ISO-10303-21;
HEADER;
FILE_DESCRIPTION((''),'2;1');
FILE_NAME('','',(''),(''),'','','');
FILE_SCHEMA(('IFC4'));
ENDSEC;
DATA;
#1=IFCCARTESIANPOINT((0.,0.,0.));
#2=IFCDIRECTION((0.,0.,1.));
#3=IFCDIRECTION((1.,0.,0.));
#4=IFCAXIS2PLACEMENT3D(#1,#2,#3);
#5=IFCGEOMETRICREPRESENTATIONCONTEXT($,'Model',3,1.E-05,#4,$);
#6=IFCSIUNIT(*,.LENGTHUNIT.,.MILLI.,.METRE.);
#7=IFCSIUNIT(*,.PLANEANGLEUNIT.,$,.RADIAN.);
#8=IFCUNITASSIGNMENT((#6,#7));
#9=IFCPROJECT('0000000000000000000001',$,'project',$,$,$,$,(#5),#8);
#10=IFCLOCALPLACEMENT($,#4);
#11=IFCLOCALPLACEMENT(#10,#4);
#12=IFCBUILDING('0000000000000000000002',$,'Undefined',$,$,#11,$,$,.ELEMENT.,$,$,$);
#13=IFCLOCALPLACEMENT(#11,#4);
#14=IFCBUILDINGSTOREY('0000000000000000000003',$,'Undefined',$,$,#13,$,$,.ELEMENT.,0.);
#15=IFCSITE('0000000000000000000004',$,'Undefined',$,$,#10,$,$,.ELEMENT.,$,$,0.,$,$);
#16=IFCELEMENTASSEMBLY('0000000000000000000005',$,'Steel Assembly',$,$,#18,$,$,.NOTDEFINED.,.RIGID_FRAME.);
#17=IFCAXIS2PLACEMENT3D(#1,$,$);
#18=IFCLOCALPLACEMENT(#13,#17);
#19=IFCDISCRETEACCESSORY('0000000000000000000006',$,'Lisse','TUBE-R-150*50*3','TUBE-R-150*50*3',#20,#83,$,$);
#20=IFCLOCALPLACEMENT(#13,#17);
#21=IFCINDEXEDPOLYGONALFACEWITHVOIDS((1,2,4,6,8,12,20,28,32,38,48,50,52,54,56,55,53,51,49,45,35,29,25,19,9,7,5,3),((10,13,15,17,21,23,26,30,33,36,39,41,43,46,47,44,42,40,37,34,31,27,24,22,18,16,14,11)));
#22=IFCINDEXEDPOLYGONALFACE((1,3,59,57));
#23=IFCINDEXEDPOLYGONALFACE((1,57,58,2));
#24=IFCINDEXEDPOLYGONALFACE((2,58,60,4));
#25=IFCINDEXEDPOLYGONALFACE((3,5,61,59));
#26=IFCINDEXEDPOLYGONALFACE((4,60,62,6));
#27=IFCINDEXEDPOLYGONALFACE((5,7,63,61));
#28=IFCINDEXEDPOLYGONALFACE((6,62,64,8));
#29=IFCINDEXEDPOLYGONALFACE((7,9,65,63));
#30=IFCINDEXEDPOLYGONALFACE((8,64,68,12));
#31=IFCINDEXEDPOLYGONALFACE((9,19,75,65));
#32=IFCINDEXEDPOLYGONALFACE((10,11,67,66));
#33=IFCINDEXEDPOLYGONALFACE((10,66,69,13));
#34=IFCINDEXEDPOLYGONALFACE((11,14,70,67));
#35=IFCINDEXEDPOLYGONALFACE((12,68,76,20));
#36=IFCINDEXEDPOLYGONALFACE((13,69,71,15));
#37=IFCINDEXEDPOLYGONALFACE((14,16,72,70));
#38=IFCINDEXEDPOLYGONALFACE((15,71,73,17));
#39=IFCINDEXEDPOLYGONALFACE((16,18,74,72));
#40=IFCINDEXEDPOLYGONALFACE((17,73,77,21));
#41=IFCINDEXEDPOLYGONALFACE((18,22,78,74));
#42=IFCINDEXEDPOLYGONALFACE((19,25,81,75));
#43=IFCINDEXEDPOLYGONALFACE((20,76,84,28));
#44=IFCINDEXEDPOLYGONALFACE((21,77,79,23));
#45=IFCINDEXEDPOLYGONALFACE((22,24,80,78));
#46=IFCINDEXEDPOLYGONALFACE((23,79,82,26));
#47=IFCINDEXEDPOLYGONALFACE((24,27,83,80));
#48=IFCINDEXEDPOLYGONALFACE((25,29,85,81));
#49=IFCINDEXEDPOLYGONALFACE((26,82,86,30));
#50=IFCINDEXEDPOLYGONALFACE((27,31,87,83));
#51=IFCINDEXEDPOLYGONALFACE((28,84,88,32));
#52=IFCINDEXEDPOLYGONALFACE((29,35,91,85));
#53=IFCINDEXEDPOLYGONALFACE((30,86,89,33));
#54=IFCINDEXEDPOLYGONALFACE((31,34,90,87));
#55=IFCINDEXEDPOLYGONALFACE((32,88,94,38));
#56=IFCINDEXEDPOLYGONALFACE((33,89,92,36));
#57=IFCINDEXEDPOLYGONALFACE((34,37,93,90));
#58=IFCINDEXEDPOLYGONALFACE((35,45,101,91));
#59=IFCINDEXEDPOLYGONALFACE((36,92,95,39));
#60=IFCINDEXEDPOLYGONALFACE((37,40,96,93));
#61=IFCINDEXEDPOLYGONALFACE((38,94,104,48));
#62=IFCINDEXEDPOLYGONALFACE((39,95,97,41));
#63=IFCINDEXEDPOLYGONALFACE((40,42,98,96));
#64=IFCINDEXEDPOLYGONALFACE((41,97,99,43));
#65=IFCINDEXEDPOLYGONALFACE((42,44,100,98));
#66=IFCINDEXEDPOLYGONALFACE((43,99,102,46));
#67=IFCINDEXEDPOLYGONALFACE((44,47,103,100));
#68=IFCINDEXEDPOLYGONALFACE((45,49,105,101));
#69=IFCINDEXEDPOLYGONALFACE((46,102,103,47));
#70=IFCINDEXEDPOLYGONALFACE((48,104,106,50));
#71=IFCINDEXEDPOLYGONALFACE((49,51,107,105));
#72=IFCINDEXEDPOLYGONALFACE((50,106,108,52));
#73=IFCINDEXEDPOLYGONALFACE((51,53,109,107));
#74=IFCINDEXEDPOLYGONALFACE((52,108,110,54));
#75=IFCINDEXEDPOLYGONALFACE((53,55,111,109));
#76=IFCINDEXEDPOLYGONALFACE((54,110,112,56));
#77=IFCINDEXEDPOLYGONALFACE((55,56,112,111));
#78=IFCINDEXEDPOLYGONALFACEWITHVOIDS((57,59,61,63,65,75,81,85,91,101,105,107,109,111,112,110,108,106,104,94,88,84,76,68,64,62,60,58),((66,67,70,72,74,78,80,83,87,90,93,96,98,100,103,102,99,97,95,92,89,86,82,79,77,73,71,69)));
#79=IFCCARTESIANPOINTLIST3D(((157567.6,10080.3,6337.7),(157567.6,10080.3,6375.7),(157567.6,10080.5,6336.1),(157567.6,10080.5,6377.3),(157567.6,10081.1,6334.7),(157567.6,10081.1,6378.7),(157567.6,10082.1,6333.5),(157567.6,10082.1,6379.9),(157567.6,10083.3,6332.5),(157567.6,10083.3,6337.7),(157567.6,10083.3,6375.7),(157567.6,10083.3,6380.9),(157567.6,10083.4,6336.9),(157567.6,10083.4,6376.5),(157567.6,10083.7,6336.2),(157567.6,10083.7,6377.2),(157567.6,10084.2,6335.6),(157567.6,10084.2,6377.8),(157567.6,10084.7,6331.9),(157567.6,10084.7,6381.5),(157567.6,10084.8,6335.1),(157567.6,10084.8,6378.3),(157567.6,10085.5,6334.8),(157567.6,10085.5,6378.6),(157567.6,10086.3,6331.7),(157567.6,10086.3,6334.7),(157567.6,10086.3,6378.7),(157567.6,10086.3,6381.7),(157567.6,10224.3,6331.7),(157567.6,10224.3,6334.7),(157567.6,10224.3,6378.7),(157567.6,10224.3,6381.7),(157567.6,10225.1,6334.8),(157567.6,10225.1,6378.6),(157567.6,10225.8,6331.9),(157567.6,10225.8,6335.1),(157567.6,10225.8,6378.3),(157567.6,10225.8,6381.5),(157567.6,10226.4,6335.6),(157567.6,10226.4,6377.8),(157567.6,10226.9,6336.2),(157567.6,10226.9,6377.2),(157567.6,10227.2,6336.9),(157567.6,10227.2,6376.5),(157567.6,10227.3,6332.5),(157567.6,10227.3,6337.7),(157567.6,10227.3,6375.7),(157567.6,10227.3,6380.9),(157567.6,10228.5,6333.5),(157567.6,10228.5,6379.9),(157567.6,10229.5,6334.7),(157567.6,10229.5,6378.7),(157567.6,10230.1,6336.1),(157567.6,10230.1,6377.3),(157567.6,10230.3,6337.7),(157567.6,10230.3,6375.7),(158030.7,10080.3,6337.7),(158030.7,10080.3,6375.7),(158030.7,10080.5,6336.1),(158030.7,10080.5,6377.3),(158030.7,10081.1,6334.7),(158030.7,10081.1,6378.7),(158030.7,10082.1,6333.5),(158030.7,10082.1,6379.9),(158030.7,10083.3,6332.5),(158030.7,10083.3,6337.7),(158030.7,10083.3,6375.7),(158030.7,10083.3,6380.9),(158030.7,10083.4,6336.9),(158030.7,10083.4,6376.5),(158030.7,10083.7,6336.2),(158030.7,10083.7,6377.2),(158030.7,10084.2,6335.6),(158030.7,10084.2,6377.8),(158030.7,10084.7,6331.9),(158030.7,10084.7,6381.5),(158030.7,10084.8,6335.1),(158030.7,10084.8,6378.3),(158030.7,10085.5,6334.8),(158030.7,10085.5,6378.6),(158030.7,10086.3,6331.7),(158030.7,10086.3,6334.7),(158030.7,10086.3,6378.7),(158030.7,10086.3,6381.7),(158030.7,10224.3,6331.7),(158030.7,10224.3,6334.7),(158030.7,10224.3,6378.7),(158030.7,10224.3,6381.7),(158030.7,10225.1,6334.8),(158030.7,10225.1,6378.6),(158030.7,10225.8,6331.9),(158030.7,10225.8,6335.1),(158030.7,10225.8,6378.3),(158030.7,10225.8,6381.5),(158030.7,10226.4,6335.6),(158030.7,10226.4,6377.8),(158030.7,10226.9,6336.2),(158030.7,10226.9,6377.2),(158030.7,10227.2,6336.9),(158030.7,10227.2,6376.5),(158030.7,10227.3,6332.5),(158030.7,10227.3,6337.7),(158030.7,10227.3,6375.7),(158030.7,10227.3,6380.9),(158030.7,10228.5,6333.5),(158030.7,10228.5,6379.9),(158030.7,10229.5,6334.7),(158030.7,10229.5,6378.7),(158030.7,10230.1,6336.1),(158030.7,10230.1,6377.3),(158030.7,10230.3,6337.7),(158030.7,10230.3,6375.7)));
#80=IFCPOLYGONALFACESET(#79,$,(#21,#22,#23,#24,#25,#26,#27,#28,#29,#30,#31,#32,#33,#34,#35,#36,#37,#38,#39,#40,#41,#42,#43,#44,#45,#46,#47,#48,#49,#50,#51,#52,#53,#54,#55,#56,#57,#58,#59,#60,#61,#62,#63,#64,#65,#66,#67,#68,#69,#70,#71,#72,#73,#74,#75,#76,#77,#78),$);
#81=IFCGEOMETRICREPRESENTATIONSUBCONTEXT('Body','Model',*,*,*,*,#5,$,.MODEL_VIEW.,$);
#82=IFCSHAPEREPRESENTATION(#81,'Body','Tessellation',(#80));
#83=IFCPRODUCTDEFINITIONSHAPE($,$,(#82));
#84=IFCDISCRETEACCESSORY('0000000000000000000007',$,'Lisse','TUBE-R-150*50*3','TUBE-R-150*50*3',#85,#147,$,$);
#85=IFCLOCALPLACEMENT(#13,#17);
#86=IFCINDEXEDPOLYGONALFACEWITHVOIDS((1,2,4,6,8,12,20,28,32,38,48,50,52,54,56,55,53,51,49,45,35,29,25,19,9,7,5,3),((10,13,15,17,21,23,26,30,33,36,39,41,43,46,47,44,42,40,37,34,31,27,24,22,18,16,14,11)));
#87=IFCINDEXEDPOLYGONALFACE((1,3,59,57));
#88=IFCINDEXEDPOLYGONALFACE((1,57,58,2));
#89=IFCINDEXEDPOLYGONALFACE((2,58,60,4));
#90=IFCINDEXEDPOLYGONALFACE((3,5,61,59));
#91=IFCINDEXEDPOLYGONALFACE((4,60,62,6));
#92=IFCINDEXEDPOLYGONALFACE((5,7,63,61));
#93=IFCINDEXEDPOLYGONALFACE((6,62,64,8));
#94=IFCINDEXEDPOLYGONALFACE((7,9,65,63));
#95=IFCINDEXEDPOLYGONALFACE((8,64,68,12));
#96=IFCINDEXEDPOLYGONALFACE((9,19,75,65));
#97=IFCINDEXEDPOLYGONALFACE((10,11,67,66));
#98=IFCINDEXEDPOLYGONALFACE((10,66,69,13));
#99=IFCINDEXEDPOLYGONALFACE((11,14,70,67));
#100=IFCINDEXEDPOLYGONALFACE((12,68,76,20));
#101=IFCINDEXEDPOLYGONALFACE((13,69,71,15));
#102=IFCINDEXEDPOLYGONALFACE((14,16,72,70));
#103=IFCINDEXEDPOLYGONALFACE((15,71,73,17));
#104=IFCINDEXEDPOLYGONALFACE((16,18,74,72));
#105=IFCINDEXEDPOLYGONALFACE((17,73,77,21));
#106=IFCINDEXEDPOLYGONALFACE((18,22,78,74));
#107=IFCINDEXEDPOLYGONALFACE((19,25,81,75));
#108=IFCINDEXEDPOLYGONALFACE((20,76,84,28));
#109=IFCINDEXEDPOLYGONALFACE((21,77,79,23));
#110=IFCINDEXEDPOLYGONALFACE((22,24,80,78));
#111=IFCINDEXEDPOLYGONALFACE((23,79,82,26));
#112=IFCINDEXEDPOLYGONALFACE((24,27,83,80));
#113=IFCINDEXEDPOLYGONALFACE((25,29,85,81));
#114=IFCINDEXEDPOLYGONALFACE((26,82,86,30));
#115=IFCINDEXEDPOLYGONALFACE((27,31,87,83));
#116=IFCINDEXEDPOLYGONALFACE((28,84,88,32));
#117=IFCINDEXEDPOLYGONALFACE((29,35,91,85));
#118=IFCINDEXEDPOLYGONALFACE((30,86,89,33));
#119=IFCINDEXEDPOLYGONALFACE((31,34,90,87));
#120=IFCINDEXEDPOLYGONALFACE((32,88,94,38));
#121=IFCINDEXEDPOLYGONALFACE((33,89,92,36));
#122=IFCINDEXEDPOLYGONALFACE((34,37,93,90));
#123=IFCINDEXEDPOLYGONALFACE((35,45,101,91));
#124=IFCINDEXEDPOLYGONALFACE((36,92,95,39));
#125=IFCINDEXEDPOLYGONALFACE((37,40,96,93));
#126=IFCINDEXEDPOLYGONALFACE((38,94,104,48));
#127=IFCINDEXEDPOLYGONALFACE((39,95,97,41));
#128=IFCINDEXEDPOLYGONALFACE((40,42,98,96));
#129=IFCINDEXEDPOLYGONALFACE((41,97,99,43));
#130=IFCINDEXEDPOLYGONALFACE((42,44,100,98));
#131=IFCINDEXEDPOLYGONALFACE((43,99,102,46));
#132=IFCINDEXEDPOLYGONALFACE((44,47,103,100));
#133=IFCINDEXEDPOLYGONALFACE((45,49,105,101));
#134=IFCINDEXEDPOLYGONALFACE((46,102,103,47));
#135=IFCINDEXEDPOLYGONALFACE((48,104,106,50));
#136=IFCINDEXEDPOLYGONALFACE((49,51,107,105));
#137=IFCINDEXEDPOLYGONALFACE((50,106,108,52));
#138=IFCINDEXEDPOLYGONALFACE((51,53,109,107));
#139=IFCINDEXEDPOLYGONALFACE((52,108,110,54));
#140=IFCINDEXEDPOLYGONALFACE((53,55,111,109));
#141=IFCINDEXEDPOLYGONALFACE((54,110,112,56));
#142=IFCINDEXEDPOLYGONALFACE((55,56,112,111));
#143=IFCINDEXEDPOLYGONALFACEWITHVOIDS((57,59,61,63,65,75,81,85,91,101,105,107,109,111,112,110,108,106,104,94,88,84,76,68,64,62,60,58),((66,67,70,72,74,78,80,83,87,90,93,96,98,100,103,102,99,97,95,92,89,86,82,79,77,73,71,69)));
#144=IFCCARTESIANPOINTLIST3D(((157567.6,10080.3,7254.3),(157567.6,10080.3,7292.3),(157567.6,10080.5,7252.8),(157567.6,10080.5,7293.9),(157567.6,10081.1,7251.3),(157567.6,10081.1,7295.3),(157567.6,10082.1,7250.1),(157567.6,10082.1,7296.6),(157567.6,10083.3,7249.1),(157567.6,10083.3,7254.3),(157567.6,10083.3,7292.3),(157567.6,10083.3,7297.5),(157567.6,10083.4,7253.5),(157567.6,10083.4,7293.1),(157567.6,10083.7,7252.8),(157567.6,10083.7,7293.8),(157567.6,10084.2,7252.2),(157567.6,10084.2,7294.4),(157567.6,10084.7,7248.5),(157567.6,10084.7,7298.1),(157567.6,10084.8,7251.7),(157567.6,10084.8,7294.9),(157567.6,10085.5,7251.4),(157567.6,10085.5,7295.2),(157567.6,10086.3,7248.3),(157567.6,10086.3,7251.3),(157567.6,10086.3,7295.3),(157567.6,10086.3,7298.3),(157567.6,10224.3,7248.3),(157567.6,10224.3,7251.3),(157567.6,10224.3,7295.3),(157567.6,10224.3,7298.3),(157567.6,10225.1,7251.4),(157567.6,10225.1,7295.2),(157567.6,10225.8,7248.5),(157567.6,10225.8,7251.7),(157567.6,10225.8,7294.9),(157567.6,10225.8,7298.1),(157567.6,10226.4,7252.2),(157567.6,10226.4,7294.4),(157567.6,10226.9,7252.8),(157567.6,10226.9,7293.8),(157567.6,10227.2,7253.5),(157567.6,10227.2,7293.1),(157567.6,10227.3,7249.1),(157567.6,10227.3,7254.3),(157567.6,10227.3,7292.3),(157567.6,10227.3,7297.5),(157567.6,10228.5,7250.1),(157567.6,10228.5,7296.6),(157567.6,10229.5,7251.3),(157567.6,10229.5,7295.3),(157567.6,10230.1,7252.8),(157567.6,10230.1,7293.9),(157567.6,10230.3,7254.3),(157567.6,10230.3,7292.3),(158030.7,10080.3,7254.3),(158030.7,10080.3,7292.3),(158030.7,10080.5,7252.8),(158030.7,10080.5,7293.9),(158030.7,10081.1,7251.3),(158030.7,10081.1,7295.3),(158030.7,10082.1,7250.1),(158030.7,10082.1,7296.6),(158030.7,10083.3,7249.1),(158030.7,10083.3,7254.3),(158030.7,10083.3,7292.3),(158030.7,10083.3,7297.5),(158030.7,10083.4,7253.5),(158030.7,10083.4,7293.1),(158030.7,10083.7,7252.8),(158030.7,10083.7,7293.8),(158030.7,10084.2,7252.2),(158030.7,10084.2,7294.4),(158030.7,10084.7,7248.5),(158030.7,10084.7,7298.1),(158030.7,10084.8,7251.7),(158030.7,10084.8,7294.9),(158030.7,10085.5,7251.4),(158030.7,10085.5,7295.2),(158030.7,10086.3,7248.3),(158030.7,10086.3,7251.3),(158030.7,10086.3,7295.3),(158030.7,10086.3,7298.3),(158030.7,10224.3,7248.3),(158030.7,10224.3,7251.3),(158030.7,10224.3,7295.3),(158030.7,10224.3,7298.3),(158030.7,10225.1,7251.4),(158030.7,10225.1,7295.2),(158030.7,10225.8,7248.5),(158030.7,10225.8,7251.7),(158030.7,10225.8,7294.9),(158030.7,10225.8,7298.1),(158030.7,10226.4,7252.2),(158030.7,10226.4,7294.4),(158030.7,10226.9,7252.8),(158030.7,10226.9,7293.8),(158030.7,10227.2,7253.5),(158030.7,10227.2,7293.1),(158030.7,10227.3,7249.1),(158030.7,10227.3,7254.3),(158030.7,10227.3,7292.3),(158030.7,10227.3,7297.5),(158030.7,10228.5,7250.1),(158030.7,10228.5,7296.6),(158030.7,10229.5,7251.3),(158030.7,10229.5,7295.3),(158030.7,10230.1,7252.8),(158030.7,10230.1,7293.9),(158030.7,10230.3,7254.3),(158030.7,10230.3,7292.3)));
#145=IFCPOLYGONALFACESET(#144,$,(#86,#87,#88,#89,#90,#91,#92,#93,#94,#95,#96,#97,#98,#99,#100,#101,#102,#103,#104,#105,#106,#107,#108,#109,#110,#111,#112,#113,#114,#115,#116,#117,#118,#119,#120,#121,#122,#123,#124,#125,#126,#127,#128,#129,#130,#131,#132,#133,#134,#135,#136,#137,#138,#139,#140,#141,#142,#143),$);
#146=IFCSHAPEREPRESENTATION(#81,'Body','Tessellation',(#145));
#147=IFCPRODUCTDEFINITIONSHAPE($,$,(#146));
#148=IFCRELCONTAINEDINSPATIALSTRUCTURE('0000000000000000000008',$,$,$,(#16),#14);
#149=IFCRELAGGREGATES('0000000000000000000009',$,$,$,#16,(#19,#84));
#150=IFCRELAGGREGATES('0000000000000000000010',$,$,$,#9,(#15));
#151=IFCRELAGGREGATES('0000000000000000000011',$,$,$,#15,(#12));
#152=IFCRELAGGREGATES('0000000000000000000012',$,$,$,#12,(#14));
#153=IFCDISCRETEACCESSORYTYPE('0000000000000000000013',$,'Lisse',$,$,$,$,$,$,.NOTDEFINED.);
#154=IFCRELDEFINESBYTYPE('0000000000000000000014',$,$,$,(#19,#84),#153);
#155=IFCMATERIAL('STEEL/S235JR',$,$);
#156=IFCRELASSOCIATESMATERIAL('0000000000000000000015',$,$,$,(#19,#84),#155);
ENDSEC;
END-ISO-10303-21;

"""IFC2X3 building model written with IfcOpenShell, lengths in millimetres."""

from ifc_helpers import new_model, si_unit, frame, origin_with_axes, origin_2d_with_axis, place, context, subcontext, project, spatial, hollow_rectangle, extrude, material, type_object, element, aggregate, save


model = new_model("IFC2X3")

# Units and contexts
model_context = context("Model", 3, precision=1e-05, world=origin_with_axes())
body_context = subcontext(model_context, "Body", "Model", "MODEL_VIEW")
ifc_project = project(units=[si_unit("LENGTHUNIT", "METRE", prefix="MILLI"), si_unit("PLANEANGLEUNIT", "RADIAN")], contexts=[model_context])

# Site, building, storey
site_placement = place(None, origin_with_axes())
site = spatial("IfcSite", under=ifc_project, at=site_placement, Name="Undefined", CompositionType="ELEMENT", RefElevation=0.0)
building_placement = place(site_placement, origin_with_axes())
building = spatial("IfcBuilding", under=site, at=building_placement, Name="Undefined", CompositionType="ELEMENT")
storey_placement = place(building_placement, origin_with_axes())
storey = spatial("IfcBuildingStorey", under=building, at=storey_placement, Name="Undefined", CompositionType="ELEMENT", Elevation=0.0)

# Element assembly
assembly_1_placement = place(storey_placement, origin_with_axes())
assembly_1 = element("IfcElementAssembly", 1, at=assembly_1_placement, inside=storey, Name="Steel Assembly", AssemblyPlace="NOTDEFINED", PredefinedType="RIGID_FRAME")
ifc_material_1 = material(Name="STEEL/S235JR")

# Shared definitions
discrete_accessory_type_1 = type_object("IfcDiscreteAccessoryType", Name="Lisse")

# Discrete accessories
discrete_accessory_1_placement = place(assembly_1_placement, frame((158030.7, 10155.3, 6356.7), z_axis=(0.0, 1.0, 0.0), x_axis=(-1.0, 0.0, 0.0)))
discrete_accessory_1 = element("IfcDiscreteAccessory", 2, at=discrete_accessory_1_placement, type_object=discrete_accessory_type_1, material=ifc_material_1, Name="Lisse", Description="TUBE-R-150*50*3", ObjectType="TUBE-R-150*50*3", context=body_context, shape_type="SweptSolid", body=[
    extrude(hollow_rectangle(XDim=50.0, YDim=150.0, WallThickness=3.0, InnerFilletRadius=3.0, OuterFilletRadius=6.0, at=origin_2d_with_axis()), frame((463.1, 0.0, 0.0), z_axis=(-1.0, 0.0, 0.0), x_axis=(0.0, -1.0, 0.0)), (0.0, 0.0, 1.0), 463.1),
])
discrete_accessory_2_placement = place(assembly_1_placement, frame((158030.7, 10155.3, 7273.3), z_axis=(0.0, 1.0, 0.0), x_axis=(-1.0, 0.0, 0.0)))
discrete_accessory_2 = element("IfcDiscreteAccessory", 3, at=discrete_accessory_2_placement, type_object=discrete_accessory_type_1, material=ifc_material_1, Name="Lisse", Description="TUBE-R-150*50*3", ObjectType="TUBE-R-150*50*3", context=body_context, shape_type="SweptSolid", body=[
    extrude(hollow_rectangle(XDim=50.0, YDim=150.0, WallThickness=3.0, InnerFilletRadius=3.0, OuterFilletRadius=6.0, at=origin_2d_with_axis()), frame((463.1, 0.0, 0.0), z_axis=(-1.0, 0.0, 0.0), x_axis=(0.0, -1.0, 0.0)), (0.0, 0.0, 1.0), 463.1),
])
aggregate(assembly_1, [discrete_accessory_1, discrete_accessory_2])

save(model, "model.ifc")
